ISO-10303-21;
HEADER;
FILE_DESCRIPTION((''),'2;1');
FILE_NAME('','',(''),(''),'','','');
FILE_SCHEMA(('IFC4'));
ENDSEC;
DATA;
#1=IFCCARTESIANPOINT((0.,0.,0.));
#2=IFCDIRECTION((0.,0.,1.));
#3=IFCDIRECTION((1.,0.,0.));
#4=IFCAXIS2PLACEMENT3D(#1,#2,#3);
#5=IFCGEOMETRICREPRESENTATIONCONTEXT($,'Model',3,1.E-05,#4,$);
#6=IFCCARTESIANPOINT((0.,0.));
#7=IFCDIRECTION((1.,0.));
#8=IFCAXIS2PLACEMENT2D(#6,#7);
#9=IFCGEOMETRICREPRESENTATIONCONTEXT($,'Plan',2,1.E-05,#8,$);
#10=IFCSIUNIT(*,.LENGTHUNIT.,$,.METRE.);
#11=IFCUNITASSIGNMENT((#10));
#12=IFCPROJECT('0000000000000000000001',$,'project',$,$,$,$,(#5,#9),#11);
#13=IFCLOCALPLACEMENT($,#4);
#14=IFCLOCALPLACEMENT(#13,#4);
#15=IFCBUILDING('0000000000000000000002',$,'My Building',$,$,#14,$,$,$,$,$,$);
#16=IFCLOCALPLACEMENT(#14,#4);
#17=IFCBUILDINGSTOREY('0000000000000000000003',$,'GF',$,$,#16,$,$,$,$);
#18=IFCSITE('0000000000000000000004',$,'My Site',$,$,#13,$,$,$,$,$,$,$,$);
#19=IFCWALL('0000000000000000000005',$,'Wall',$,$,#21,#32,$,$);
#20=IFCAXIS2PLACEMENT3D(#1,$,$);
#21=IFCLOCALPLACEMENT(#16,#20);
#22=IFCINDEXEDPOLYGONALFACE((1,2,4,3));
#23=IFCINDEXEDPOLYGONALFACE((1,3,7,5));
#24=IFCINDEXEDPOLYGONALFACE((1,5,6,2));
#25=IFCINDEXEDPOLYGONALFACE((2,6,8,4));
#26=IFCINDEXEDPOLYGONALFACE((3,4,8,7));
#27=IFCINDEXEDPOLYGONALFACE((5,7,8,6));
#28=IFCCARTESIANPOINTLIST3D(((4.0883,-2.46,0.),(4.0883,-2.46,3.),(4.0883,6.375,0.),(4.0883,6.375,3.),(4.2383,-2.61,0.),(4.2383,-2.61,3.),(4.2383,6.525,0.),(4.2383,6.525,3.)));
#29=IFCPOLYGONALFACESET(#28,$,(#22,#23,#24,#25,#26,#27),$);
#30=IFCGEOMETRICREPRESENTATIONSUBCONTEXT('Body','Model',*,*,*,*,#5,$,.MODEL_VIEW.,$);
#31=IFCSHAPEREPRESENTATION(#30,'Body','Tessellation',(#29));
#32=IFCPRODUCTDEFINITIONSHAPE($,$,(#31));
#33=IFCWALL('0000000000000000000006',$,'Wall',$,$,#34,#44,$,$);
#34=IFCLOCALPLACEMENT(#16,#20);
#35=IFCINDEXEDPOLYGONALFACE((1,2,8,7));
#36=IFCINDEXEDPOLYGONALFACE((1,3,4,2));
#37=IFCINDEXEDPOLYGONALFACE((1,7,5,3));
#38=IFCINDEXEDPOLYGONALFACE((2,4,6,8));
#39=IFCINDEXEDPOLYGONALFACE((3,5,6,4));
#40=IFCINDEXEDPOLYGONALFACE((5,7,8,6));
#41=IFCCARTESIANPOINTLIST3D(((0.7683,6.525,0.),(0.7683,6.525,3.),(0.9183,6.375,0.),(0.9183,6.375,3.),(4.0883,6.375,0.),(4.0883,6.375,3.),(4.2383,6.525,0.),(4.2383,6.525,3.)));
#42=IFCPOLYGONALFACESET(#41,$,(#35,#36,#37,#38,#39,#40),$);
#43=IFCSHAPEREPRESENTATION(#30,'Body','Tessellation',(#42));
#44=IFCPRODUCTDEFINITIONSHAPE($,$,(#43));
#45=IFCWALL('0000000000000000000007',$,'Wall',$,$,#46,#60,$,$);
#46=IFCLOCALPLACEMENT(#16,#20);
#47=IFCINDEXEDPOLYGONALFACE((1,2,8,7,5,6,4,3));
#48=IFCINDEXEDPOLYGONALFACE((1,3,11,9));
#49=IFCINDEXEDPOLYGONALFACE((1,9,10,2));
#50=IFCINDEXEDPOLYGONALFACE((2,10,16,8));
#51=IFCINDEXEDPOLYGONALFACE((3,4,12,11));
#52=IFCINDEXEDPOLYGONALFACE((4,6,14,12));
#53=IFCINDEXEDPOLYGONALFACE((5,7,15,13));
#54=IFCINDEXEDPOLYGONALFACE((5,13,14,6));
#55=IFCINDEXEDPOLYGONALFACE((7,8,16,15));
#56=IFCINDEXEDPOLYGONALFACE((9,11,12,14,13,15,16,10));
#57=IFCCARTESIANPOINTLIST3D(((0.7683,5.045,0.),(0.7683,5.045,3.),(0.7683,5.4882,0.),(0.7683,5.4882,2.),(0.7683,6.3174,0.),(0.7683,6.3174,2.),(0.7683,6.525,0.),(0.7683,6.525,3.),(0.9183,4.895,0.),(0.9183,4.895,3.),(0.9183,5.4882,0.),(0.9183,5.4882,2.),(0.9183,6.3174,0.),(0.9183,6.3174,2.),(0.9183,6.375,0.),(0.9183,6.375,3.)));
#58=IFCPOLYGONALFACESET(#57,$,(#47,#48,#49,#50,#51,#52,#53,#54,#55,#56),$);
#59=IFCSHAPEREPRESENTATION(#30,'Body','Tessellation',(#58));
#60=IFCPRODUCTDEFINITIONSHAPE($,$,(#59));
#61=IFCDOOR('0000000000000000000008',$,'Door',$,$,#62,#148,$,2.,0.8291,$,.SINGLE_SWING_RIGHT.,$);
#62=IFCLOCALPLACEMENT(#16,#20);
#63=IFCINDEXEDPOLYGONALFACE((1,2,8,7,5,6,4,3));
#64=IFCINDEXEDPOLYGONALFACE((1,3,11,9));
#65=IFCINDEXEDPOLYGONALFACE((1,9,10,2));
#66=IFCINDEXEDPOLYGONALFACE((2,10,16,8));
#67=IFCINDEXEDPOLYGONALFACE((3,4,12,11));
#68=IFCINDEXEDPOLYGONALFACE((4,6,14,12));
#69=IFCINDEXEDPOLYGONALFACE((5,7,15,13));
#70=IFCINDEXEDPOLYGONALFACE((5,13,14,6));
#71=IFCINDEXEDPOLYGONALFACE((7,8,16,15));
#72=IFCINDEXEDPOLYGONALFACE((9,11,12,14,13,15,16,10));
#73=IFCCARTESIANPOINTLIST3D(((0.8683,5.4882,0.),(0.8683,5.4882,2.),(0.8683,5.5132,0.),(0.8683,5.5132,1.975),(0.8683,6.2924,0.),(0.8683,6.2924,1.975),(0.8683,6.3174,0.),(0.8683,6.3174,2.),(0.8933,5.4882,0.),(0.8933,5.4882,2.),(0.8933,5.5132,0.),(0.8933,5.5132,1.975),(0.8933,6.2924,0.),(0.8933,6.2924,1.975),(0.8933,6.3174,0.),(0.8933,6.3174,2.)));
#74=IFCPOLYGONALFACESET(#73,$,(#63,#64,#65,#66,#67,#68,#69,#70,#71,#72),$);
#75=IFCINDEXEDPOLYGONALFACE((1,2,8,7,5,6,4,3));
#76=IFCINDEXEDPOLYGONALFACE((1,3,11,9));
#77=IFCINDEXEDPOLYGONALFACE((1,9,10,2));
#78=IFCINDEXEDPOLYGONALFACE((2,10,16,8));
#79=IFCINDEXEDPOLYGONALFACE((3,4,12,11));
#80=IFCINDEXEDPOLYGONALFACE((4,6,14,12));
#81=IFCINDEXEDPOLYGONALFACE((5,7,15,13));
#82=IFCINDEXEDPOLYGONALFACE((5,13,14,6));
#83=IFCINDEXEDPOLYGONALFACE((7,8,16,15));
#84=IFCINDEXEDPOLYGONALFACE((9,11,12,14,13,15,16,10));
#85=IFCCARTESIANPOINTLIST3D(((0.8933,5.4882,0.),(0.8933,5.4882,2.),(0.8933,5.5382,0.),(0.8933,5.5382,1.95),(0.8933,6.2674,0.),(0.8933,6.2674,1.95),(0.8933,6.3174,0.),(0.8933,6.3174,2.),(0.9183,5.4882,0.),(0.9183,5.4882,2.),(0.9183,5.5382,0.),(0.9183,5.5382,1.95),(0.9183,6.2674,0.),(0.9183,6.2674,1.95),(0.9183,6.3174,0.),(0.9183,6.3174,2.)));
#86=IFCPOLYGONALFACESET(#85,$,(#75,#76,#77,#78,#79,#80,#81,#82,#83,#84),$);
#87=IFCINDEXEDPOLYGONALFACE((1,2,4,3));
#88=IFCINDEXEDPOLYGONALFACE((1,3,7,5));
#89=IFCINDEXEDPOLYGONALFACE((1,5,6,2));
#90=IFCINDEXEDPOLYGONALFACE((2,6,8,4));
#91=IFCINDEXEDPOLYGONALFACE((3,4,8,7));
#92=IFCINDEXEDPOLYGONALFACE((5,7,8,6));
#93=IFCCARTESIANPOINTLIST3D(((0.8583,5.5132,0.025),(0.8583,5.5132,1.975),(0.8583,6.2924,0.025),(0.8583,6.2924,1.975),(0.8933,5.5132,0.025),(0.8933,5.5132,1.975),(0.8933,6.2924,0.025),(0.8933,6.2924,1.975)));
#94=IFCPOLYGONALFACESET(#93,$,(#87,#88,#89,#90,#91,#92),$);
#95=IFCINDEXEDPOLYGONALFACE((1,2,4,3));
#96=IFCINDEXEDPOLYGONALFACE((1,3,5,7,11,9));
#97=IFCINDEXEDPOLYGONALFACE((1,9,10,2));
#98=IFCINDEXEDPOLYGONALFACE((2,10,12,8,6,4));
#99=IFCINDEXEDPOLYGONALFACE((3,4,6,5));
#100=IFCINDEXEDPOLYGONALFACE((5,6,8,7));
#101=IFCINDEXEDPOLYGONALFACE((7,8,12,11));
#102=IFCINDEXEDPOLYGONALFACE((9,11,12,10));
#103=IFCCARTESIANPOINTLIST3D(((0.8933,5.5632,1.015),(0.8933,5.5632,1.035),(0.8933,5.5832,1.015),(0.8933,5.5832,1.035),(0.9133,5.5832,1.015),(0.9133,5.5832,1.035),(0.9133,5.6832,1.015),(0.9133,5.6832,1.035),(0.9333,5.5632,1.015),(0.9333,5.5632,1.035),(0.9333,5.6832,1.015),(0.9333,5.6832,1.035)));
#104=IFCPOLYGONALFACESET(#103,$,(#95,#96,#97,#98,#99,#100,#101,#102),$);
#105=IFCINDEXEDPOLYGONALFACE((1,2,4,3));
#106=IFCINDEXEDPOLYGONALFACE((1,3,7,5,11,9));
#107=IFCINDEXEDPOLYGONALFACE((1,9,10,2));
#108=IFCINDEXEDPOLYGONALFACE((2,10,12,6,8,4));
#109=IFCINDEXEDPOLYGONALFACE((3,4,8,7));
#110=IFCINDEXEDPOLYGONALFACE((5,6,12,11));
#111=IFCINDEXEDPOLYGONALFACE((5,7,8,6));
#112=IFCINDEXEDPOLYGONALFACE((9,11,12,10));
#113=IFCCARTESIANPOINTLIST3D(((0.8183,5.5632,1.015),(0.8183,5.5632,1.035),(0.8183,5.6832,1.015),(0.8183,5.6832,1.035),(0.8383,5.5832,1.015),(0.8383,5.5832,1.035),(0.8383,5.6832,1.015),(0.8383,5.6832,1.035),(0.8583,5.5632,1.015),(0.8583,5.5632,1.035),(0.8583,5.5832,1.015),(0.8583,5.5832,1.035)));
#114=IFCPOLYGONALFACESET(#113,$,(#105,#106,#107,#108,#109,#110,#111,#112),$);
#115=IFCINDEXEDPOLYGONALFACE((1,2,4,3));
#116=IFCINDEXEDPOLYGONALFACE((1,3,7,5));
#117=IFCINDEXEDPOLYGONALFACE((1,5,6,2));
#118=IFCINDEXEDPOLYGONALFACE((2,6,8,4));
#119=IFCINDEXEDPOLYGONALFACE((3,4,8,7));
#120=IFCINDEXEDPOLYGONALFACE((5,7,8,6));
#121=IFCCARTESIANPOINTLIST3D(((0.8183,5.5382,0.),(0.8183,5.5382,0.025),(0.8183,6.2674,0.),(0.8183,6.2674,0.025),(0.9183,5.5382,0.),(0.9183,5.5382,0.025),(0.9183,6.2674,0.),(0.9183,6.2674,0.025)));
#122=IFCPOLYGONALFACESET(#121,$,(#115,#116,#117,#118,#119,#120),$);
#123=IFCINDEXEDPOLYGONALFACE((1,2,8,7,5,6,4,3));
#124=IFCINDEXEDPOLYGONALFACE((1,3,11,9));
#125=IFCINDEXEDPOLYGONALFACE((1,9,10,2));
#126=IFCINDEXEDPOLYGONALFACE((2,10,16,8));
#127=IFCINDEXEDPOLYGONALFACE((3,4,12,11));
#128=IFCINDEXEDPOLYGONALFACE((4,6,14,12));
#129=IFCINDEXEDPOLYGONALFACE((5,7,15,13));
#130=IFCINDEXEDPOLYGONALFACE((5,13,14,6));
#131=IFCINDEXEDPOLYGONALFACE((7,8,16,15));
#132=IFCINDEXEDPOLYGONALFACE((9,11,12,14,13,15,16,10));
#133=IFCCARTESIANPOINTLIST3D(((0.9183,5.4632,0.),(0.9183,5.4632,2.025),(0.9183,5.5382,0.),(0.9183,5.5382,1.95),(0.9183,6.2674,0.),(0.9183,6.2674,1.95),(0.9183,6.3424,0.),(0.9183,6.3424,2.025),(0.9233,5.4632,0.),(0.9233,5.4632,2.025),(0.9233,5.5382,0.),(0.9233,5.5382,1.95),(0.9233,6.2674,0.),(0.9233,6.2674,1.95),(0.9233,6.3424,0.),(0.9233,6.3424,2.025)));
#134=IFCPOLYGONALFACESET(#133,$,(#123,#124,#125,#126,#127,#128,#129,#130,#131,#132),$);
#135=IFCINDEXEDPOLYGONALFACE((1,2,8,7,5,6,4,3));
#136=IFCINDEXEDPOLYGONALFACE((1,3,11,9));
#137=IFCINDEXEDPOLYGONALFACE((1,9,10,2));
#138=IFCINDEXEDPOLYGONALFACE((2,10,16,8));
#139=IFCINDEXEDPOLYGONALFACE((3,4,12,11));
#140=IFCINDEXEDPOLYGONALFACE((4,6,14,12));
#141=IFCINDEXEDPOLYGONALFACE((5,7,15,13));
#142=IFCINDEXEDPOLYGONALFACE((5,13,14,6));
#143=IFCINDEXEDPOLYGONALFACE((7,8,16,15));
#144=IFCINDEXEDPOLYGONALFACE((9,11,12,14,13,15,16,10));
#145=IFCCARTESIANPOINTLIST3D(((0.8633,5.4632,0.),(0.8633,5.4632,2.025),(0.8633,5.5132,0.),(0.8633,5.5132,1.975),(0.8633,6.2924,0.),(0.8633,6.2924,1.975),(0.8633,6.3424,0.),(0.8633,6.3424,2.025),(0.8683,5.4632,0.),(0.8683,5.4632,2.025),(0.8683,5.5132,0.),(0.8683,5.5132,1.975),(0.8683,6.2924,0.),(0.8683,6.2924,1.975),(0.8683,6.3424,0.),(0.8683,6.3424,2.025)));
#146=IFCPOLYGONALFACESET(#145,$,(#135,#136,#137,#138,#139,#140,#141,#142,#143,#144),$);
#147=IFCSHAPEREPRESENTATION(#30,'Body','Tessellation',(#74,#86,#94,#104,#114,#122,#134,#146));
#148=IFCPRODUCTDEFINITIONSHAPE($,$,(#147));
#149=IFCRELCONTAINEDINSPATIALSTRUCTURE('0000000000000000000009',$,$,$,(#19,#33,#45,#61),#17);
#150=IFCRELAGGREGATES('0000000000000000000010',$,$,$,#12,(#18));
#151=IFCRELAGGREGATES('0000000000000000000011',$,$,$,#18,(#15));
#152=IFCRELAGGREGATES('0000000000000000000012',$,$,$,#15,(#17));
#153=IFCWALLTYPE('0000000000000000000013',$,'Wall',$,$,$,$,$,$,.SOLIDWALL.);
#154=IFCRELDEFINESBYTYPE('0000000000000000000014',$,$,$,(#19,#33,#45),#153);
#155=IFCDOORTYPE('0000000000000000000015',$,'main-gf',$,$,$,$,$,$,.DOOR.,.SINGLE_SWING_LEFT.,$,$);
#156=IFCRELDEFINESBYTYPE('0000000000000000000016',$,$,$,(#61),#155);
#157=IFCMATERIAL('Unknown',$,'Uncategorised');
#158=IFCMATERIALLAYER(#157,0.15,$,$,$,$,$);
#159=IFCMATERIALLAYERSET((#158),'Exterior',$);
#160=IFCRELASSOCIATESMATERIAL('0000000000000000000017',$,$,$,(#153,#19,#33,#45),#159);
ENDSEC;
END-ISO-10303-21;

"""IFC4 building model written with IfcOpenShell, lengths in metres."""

from ifc_helpers import new_model, entity, si_unit, frame, origin_with_axes, origin_2d_with_axis, place, context, subcontext, project, spatial, line, indexed_curve, outline, extrude, shape, source, transform, mapped, material, layer, layer_set, layer_usage, type_object, type_shapes, element, fill, save


model = new_model("IFC4")

# Units and contexts
model_context = context("Model", 3, precision=1e-05, world=origin_with_axes())
plan_context = context("Plan", 2, precision=1e-05, world=origin_2d_with_axis())
body_context_1 = subcontext(model_context, "Body", "Model", "MODEL_VIEW")
body_context_2 = subcontext(plan_context, "Body", "Plan", "PLAN_VIEW")
ifc_project = project(units=[si_unit("LENGTHUNIT", "METRE")], contexts=[model_context, plan_context])

# Site, building, storey
site_placement = place(None, origin_with_axes())
site = spatial("IfcSite", under=ifc_project, at=site_placement, Name="My Site")
building_placement = place(site_placement, origin_with_axes())
building = spatial("IfcBuilding", under=site, at=building_placement, Name="My Building")
storey_placement = place(building_placement, origin_with_axes())
storey = spatial("IfcBuildingStorey", under=building, at=storey_placement, Name="GF")

# Shared definitions
ifc_material = material(Name="Unknown", Category="Uncategorised")

# Shared definitions
ifc_layer_1 = layer(ifc_material, 0.15)
ifc_layer_set_1 = layer_set([ifc_layer_1], Name="Exterior")
wall_type_1 = type_object("IfcWallType", Name="Wall", PredefinedType="SOLIDWALL", material=ifc_layer_set_1)
shared_shape_1 = source(origin_with_axes(), body_context_1, "Body", "SweptSolid", [
    extrude(outline(indexed_curve([(0.0, 0.0), (0.8291, 0.0), (0.8291, 2.0), (0.0, 2.0)], segments=[line(1, 2, 3, 4, 1)])), frame((0.0, -0.6, 0.0), z_axis=(0.0, -1.0, 0.0), x_axis=(1.0, 0.0, 0.0)), (0.0, 0.0, -1.0), 1.2),
])
door_type_1 = type_object("IfcDoorType", Name="main-gf", OperationType="SINGLE_SWING_LEFT", PredefinedType="DOOR")
shared_shape_2 = source(origin_with_axes(), body_context_1, "Body", "SweptSolid", [
    extrude(outline(indexed_curve([(0.0, 0.0), (0.0, 2.0), (0.8291, 2.0), (0.8291, 0.0), (0.8041, 0.0), (0.8041, 1.975), (0.025, 1.975), (0.025, 0.0)], segments=[line(1, 2, 3, 4, 5, 6, 7, 8, 1)])), frame((0.0, 0.025, 0.0), z_axis=(0.0, -1.0, 0.0), x_axis=(1.0, 0.0, 0.0)), (0.0, 0.0, -1.0), 0.025),
    extrude(outline(indexed_curve([(0.0, 0.0), (0.0, 2.0), (0.8291, 2.0), (0.8291, 0.0), (0.7791, 0.0), (0.7791, 1.95), (0.05, 1.95), (0.05, 0.0)], segments=[line(1, 2, 3, 4, 5, 6, 7, 8, 1)])), frame((0.0, 0.0, 0.0), z_axis=(0.0, -1.0, 0.0), x_axis=(1.0, 0.0, 0.0)), (0.0, 0.0, -1.0), 0.025),
    extrude(outline(indexed_curve([(0.0, 0.0), (0.7791, 0.0), (0.7791, 0.035), (0.0, 0.035)], segments=[line(1, 2, 3, 4, 1)])), frame((0.025, 0.025, 0.025), z_axis=(0.0, 0.0, 1.0), x_axis=(1.0, 0.0, 0.0)), (0.0, 0.0, 1.0), 1.95),
    extrude(outline(indexed_curve([(0.0, 0.0), (0.0, -0.04), (0.12, -0.04), (0.12, -0.02), (0.02, -0.02), (0.02, 0.0)], segments=[line(1, 2, 3, 4, 5, 6, 1)])), frame((0.075, 0.025, 1.015), z_axis=(0.0, 0.0, 1.0), x_axis=(1.0, 0.0, 0.0)), (0.0, 0.0, 1.0), 0.02),
    extrude(outline(indexed_curve([(0.0, 0.0), (0.0, 0.04), (0.12, 0.04), (0.12, 0.02), (0.02, 0.02), (0.02, 0.0)], segments=[line(1, 2, 3, 4, 5, 6, 1)])), frame((0.075, 0.06, 1.015), z_axis=(0.0, 0.0, 1.0), x_axis=(1.0, 0.0, 0.0)), (0.0, 0.0, 1.0), 0.02),
    extrude(outline(indexed_curve([(0.0, 0.0), (0.7291, 0.0), (0.7291, 0.1), (0.0, 0.1)], segments=[line(1, 2, 3, 4, 1)])), frame((0.05, 0.0, 0.0), z_axis=(0.0, 0.0, 1.0), x_axis=(1.0, 0.0, 0.0)), (0.0, 0.0, 1.0), 0.025),
    extrude(outline(indexed_curve([(0.0, 0.0), (0.0, 2.025), (0.8791, 2.025), (0.8791, 0.0), (0.8041, 0.0), (0.8041, 1.95), (0.075, 1.95), (0.075, 0.0)], segments=[line(1, 2, 3, 4, 5, 6, 7, 8, 1)])), frame((-0.025, -0.005, 0.0), z_axis=(0.0, -1.0, 0.0), x_axis=(1.0, 0.0, 0.0)), (0.0, 0.0, -1.0), 0.005),
    extrude(outline(indexed_curve([(0.0, 0.0), (0.0, 2.025), (0.8791, 2.025), (0.8791, 0.0), (0.8291, 0.0), (0.8291, 1.975), (0.05, 1.975), (0.05, 0.0)], segments=[line(1, 2, 3, 4, 5, 6, 7, 8, 1)])), frame((-0.025, 0.05, 0.0), z_axis=(0.0, -1.0, 0.0), x_axis=(1.0, 0.0, 0.0)), (0.0, 0.0, -1.0), 0.005),
])
shared_shape_3 = source(origin_with_axes(), body_context_2, "Body", "Curve2D", [
    entity("IfcIndexedPolyCurve", entity("IfcCartesianPointList2D", [[0.0, 0.0], [0.0, 0.05], [0.025, 0.05], [0.025, 0.025], [0.05, 0.025], [0.05, 0.0]]), [entity("IfcLineIndex", [1, 2, 3, 4, 5, 6, 1])]),
    entity("IfcIndexedPolyCurve", entity("IfcCartesianPointList2D", [[0.8291, 0.0], [0.8291, 0.05], [0.8041, 0.05], [0.8041, 0.025], [0.7791, 0.025], [0.7791, 0.0]]), [entity("IfcLineIndex", [1, 2, 3, 4, 5, 6, 1])]),
    entity("IfcTrimmedCurve", entity("IfcEllipse", entity("IfcAxis2Placement2D", entity("IfcCartesianPoint", [0.7691, 0.05]), entity("IfcDirection", [1.0, 0.0])), 0.7441, 0.7791), [entity("IfcCartesianPoint", [0.7691, 0.8291])], [entity("IfcCartesianPoint", [0.025, 0.05])], True, "CARTESIAN"),
    entity("IfcIndexedPolyCurve", entity("IfcCartesianPointList2D", [[0.8041, 0.05], [0.7691, 0.05], [0.7691, 0.8291], [0.8041, 0.8291]]), [entity("IfcLineIndex", [1, 2, 3, 4, 1])]),
])
type_shapes(door_type_1, [shared_shape_2, shared_shape_3])

# Walls
ifc_layer_usage_1 = layer_usage(ifc_layer_set_1, "AXIS2", "POSITIVE", 0.0)
wall_1_placement = place(storey_placement, frame((4.2383, -2.61, 0.0), z_axis=(0.0, 0.0, 1.0), x_axis=(0.0, 1.0, 0.0)))
element("IfcWall", 1, at=wall_1_placement, inside=storey, type_object=wall_type_1, material=ifc_layer_usage_1, Name="Wall", context=body_context_1, shape_type="SweptSolid", body=[
    extrude(outline(indexed_curve([(0.0, 0.0), (0.15, 0.15), (8.985, 0.15), (9.135, 0.0)], segments=[line(1, 2, 3, 4, 1)])), origin_with_axes(), (0.0, 0.0, 1.0), 3.0),
])
ifc_layer_usage_2 = layer_usage(ifc_layer_set_1, "AXIS2", "POSITIVE", 0.0)
wall_2_placement = place(storey_placement, frame((4.2383, 6.525, 0.0), z_axis=(0.0, 0.0, 1.0), x_axis=(-1.0, 0.0, 0.0)))
element("IfcWall", 2, at=wall_2_placement, inside=storey, type_object=wall_type_1, material=ifc_layer_usage_2, Name="Wall", context=body_context_1, shape_type="SweptSolid", body=[
    extrude(outline(indexed_curve([(0.0, 0.0), (0.15, 0.15), (3.32, 0.15), (3.47, 0.0)], segments=[line(1, 2, 3, 4, 1)])), origin_with_axes(), (0.0, 0.0, 1.0), 3.0),
])

# Wall, opening, door
ifc_layer_usage_3 = layer_usage(ifc_layer_set_1, "AXIS2", "POSITIVE", 0.0)
wall_3_placement = place(storey_placement, frame((0.7683, 6.525, 0.0), z_axis=(0.0, 0.0, 1.0), x_axis=(0.0, -1.0, 0.0)))
wall_3 = element("IfcWall", 3, at=wall_3_placement, inside=storey, type_object=wall_type_1, material=ifc_layer_usage_3, Name="Wall", context=body_context_1, shape_type="SweptSolid", body=[
    extrude(outline(indexed_curve([(0.0, 0.0), (0.15, 0.15), (1.63, 0.15), (1.48, 0.0)], segments=[line(1, 2, 3, 4, 1)])), origin_with_axes(), (0.0, 0.0, 1.0), 3.0),
])
opening_1_placement = place(wall_3_placement, frame((1.0368, 0.15, 0.0), z_axis=(0.0, 0.0, 1.0), x_axis=(-1.0, 0.0, 0.0)))
opening_1 = element("IfcOpeningElement", 4, at=opening_1_placement, cuts=wall_3, PredefinedType="OPENING", context=body_context_1, shape_type="MappedRepresentation", body=[
    mapped(shared_shape_1, transform((0.0, 0.0, 0.0), x_axis=(1.0, 0.0, 0.0), y_axis=(0.0, 1.0, 0.0), z_axis=(0.0, 0.0, 1.0), scale=1.0)),
])
door_1_placement = place(opening_1_placement, frame((0.0, 0.0, 0.0), z_axis=(0.0, 0.0, 1.0), x_axis=(1.0, 0.0, 0.0)))
door_1 = element("IfcDoor", 5, at=door_1_placement, inside=storey, type_object=door_type_1, Name="Door", OperationType="SINGLE_SWING_RIGHT", OverallHeight=2.0, OverallWidth=0.8291, shapes=[
    shape(body_context_1, "Body", "MappedRepresentation", [mapped(shared_shape_2, transform((0.0, 0.0, 0.0), x_axis=(1.0, 0.0, 0.0), y_axis=(0.0, 1.0, 0.0), z_axis=(0.0, 0.0, 1.0), scale=1.0))]),
    shape(body_context_2, "Body", "MappedRepresentation", [mapped(shared_shape_3, transform((0.0, 0.0, 0.0), x_axis=(1.0, 0.0, 0.0), y_axis=(0.0, 1.0, 0.0), z_axis=(0.0, 0.0, 1.0), scale=1.0))]),
])
fill(opening_1, door_1)

save(model, "model.ifc")
